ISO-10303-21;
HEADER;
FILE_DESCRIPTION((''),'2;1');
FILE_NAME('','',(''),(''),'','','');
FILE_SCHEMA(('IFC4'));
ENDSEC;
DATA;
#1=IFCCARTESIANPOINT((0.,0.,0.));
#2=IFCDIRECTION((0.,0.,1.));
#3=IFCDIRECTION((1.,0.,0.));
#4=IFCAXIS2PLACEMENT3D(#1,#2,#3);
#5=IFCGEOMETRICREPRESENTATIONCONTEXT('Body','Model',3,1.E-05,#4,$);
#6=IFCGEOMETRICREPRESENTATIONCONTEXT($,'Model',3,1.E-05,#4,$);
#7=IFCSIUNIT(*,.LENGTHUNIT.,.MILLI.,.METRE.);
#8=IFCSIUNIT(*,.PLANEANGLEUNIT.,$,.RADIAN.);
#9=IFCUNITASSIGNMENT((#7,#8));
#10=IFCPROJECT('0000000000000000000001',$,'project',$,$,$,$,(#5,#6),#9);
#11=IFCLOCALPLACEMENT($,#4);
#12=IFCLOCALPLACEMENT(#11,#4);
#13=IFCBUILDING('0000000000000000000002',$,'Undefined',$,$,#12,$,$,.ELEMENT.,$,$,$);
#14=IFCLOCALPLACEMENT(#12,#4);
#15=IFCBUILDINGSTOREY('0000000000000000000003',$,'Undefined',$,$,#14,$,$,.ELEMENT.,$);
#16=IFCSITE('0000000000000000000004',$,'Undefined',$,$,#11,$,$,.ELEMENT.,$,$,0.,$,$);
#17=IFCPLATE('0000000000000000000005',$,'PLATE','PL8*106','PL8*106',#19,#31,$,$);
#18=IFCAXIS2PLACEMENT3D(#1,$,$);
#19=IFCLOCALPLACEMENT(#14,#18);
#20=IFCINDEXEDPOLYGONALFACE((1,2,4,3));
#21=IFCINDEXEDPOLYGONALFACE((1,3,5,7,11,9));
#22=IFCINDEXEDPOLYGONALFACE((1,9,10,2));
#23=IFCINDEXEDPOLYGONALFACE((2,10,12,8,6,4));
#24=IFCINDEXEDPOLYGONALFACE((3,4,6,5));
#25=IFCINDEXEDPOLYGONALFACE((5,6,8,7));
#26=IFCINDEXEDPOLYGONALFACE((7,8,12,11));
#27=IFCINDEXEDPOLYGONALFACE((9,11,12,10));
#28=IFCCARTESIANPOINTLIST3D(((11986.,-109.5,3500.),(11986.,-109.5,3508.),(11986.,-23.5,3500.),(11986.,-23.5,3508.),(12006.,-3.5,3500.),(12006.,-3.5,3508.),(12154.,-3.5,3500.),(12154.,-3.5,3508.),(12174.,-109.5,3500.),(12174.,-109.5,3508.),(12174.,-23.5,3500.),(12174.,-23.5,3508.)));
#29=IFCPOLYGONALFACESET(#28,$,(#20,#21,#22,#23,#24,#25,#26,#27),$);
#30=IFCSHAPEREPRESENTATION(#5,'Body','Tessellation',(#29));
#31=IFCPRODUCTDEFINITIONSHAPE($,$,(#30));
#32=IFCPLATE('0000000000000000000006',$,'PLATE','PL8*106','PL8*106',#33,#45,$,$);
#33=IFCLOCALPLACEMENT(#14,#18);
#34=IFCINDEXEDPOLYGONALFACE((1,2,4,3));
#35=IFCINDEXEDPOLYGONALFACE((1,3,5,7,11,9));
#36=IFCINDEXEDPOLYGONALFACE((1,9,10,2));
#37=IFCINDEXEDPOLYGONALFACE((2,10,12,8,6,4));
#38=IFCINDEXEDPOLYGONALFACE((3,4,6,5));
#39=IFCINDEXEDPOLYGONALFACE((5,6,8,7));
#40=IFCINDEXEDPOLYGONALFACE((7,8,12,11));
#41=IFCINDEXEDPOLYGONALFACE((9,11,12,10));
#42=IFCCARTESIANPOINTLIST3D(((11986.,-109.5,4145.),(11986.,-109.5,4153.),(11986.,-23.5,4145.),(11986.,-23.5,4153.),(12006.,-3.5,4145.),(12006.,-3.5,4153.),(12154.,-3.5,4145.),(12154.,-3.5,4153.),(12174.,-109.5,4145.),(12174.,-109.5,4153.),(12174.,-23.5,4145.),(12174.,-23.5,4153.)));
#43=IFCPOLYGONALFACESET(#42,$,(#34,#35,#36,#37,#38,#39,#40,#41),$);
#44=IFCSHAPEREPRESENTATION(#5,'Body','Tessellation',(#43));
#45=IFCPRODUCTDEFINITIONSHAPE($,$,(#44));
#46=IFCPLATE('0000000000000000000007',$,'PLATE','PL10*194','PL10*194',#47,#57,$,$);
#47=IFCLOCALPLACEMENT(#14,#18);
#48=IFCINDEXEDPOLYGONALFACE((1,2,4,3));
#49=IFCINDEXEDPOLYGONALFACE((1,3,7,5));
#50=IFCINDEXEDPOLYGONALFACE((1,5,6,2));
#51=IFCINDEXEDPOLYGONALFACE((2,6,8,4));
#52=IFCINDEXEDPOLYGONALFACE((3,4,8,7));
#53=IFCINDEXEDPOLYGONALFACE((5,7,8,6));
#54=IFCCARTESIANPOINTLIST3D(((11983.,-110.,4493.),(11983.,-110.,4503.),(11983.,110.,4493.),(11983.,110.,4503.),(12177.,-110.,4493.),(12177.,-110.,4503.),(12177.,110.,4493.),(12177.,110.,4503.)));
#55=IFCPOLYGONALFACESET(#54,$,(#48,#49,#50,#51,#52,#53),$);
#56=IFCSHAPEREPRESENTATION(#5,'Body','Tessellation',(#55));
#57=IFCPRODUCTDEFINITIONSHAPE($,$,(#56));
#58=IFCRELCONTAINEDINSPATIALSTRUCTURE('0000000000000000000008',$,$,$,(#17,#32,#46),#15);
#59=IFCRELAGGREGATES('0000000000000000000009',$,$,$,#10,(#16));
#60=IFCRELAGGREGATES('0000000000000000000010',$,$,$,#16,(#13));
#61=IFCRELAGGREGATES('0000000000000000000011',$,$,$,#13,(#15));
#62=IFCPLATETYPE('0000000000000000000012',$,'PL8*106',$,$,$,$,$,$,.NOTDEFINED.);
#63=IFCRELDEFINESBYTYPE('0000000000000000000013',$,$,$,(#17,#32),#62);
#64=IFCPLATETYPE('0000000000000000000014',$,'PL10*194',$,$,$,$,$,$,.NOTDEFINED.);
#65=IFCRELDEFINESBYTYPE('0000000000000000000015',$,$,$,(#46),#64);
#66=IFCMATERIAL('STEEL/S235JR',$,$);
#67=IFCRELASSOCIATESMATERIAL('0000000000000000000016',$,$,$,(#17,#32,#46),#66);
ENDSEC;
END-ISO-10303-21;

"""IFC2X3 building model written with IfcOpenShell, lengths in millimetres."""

from ifc_helpers import new_model, si_unit, frame, origin_with_axes, place, context, project, spatial, polyline, outline, extrude, material, type_object, element, save


model = new_model("IFC2X3")

# Units and contexts
model_context_1 = context("Model", 3, precision=1e-05, world=origin_with_axes(), identifier="Body")
model_context_2 = context("Model", 3, precision=1e-05, world=origin_with_axes())
ifc_project = project(units=[si_unit("LENGTHUNIT", "METRE", prefix="MILLI"), si_unit("PLANEANGLEUNIT", "RADIAN")], contexts=[model_context_1, model_context_2])

# Site, building, storey
site_placement = place(None, origin_with_axes())
site = spatial("IfcSite", under=ifc_project, at=site_placement, Name="Undefined", CompositionType="ELEMENT", RefElevation=0.0)
building_placement = place(site_placement, origin_with_axes())
building = spatial("IfcBuilding", under=site, at=building_placement, Name="Undefined", CompositionType="ELEMENT")
storey_placement = place(building_placement, origin_with_axes())
storey = spatial("IfcBuildingStorey", under=building, at=storey_placement, Name="Undefined", CompositionType="ELEMENT")

# Shared definitions
ifc_material = material(Name="STEEL/S235JR")

# Plates
plate_type_1 = type_object("IfcPlateType", Name="PL8*106", PredefinedType="NOTDEFINED")
for number, where, z_axis, x_axis, name in (
    (1, (11986.0, -109.5, 3504.0), (0.0, 0.0, -1.0), (0.0, 1.0, 0.0), "PLATE"),
    (2, (11986.0, -109.5, 4149.0), (0.0, 0.0, -1.0), (0.0, 1.0, 0.0), "PLATE"),
):
    element("IfcPlate", number, at=place(storey_placement, frame(where, z_axis=z_axis, x_axis=x_axis)), inside=storey, type_object=plate_type_1, material=ifc_material, Name=name, Description="PL8*106", ObjectType="PL8*106", context=model_context_1, shape_type="SweptSolid", body=[
        extrude(outline(polyline([(0.0, 0.0), (86.0, 0.0), (106.0, 20.0), (106.0, 168.0), (86.0, 188.0), (0.0, 188.0), (0.0, 0.0)])), frame((0.0, 0.0, -4.0), z_axis=(0.0, 0.0, 1.0), x_axis=(1.0, 0.0, 0.0)), (0.0, 0.0, 1.0), 8.0),
    ])
plate_type_2 = type_object("IfcPlateType", Name="PL10*194", PredefinedType="NOTDEFINED")
plate_1_placement = place(storey_placement, frame((11983.0, 110.0, 4498.0), z_axis=(0.0, 0.0, -1.0), x_axis=(1.0, 0.0, 0.0)))
element("IfcPlate", 3, at=plate_1_placement, inside=storey, type_object=plate_type_2, material=ifc_material, Name="PLATE", Description="PL10*194", ObjectType="PL10*194", context=model_context_1, shape_type="SweptSolid", body=[
    extrude(outline(polyline([(0.0, 0.0), (194.0, 0.0), (194.0, 220.0), (0.0, 220.0), (0.0, 0.0)])), frame((0.0, 0.0, -5.0), z_axis=(0.0, 0.0, 1.0), x_axis=(1.0, 0.0, 0.0)), (0.0, 0.0, 1.0), 10.0),
])

save(model, "model.ifc")
